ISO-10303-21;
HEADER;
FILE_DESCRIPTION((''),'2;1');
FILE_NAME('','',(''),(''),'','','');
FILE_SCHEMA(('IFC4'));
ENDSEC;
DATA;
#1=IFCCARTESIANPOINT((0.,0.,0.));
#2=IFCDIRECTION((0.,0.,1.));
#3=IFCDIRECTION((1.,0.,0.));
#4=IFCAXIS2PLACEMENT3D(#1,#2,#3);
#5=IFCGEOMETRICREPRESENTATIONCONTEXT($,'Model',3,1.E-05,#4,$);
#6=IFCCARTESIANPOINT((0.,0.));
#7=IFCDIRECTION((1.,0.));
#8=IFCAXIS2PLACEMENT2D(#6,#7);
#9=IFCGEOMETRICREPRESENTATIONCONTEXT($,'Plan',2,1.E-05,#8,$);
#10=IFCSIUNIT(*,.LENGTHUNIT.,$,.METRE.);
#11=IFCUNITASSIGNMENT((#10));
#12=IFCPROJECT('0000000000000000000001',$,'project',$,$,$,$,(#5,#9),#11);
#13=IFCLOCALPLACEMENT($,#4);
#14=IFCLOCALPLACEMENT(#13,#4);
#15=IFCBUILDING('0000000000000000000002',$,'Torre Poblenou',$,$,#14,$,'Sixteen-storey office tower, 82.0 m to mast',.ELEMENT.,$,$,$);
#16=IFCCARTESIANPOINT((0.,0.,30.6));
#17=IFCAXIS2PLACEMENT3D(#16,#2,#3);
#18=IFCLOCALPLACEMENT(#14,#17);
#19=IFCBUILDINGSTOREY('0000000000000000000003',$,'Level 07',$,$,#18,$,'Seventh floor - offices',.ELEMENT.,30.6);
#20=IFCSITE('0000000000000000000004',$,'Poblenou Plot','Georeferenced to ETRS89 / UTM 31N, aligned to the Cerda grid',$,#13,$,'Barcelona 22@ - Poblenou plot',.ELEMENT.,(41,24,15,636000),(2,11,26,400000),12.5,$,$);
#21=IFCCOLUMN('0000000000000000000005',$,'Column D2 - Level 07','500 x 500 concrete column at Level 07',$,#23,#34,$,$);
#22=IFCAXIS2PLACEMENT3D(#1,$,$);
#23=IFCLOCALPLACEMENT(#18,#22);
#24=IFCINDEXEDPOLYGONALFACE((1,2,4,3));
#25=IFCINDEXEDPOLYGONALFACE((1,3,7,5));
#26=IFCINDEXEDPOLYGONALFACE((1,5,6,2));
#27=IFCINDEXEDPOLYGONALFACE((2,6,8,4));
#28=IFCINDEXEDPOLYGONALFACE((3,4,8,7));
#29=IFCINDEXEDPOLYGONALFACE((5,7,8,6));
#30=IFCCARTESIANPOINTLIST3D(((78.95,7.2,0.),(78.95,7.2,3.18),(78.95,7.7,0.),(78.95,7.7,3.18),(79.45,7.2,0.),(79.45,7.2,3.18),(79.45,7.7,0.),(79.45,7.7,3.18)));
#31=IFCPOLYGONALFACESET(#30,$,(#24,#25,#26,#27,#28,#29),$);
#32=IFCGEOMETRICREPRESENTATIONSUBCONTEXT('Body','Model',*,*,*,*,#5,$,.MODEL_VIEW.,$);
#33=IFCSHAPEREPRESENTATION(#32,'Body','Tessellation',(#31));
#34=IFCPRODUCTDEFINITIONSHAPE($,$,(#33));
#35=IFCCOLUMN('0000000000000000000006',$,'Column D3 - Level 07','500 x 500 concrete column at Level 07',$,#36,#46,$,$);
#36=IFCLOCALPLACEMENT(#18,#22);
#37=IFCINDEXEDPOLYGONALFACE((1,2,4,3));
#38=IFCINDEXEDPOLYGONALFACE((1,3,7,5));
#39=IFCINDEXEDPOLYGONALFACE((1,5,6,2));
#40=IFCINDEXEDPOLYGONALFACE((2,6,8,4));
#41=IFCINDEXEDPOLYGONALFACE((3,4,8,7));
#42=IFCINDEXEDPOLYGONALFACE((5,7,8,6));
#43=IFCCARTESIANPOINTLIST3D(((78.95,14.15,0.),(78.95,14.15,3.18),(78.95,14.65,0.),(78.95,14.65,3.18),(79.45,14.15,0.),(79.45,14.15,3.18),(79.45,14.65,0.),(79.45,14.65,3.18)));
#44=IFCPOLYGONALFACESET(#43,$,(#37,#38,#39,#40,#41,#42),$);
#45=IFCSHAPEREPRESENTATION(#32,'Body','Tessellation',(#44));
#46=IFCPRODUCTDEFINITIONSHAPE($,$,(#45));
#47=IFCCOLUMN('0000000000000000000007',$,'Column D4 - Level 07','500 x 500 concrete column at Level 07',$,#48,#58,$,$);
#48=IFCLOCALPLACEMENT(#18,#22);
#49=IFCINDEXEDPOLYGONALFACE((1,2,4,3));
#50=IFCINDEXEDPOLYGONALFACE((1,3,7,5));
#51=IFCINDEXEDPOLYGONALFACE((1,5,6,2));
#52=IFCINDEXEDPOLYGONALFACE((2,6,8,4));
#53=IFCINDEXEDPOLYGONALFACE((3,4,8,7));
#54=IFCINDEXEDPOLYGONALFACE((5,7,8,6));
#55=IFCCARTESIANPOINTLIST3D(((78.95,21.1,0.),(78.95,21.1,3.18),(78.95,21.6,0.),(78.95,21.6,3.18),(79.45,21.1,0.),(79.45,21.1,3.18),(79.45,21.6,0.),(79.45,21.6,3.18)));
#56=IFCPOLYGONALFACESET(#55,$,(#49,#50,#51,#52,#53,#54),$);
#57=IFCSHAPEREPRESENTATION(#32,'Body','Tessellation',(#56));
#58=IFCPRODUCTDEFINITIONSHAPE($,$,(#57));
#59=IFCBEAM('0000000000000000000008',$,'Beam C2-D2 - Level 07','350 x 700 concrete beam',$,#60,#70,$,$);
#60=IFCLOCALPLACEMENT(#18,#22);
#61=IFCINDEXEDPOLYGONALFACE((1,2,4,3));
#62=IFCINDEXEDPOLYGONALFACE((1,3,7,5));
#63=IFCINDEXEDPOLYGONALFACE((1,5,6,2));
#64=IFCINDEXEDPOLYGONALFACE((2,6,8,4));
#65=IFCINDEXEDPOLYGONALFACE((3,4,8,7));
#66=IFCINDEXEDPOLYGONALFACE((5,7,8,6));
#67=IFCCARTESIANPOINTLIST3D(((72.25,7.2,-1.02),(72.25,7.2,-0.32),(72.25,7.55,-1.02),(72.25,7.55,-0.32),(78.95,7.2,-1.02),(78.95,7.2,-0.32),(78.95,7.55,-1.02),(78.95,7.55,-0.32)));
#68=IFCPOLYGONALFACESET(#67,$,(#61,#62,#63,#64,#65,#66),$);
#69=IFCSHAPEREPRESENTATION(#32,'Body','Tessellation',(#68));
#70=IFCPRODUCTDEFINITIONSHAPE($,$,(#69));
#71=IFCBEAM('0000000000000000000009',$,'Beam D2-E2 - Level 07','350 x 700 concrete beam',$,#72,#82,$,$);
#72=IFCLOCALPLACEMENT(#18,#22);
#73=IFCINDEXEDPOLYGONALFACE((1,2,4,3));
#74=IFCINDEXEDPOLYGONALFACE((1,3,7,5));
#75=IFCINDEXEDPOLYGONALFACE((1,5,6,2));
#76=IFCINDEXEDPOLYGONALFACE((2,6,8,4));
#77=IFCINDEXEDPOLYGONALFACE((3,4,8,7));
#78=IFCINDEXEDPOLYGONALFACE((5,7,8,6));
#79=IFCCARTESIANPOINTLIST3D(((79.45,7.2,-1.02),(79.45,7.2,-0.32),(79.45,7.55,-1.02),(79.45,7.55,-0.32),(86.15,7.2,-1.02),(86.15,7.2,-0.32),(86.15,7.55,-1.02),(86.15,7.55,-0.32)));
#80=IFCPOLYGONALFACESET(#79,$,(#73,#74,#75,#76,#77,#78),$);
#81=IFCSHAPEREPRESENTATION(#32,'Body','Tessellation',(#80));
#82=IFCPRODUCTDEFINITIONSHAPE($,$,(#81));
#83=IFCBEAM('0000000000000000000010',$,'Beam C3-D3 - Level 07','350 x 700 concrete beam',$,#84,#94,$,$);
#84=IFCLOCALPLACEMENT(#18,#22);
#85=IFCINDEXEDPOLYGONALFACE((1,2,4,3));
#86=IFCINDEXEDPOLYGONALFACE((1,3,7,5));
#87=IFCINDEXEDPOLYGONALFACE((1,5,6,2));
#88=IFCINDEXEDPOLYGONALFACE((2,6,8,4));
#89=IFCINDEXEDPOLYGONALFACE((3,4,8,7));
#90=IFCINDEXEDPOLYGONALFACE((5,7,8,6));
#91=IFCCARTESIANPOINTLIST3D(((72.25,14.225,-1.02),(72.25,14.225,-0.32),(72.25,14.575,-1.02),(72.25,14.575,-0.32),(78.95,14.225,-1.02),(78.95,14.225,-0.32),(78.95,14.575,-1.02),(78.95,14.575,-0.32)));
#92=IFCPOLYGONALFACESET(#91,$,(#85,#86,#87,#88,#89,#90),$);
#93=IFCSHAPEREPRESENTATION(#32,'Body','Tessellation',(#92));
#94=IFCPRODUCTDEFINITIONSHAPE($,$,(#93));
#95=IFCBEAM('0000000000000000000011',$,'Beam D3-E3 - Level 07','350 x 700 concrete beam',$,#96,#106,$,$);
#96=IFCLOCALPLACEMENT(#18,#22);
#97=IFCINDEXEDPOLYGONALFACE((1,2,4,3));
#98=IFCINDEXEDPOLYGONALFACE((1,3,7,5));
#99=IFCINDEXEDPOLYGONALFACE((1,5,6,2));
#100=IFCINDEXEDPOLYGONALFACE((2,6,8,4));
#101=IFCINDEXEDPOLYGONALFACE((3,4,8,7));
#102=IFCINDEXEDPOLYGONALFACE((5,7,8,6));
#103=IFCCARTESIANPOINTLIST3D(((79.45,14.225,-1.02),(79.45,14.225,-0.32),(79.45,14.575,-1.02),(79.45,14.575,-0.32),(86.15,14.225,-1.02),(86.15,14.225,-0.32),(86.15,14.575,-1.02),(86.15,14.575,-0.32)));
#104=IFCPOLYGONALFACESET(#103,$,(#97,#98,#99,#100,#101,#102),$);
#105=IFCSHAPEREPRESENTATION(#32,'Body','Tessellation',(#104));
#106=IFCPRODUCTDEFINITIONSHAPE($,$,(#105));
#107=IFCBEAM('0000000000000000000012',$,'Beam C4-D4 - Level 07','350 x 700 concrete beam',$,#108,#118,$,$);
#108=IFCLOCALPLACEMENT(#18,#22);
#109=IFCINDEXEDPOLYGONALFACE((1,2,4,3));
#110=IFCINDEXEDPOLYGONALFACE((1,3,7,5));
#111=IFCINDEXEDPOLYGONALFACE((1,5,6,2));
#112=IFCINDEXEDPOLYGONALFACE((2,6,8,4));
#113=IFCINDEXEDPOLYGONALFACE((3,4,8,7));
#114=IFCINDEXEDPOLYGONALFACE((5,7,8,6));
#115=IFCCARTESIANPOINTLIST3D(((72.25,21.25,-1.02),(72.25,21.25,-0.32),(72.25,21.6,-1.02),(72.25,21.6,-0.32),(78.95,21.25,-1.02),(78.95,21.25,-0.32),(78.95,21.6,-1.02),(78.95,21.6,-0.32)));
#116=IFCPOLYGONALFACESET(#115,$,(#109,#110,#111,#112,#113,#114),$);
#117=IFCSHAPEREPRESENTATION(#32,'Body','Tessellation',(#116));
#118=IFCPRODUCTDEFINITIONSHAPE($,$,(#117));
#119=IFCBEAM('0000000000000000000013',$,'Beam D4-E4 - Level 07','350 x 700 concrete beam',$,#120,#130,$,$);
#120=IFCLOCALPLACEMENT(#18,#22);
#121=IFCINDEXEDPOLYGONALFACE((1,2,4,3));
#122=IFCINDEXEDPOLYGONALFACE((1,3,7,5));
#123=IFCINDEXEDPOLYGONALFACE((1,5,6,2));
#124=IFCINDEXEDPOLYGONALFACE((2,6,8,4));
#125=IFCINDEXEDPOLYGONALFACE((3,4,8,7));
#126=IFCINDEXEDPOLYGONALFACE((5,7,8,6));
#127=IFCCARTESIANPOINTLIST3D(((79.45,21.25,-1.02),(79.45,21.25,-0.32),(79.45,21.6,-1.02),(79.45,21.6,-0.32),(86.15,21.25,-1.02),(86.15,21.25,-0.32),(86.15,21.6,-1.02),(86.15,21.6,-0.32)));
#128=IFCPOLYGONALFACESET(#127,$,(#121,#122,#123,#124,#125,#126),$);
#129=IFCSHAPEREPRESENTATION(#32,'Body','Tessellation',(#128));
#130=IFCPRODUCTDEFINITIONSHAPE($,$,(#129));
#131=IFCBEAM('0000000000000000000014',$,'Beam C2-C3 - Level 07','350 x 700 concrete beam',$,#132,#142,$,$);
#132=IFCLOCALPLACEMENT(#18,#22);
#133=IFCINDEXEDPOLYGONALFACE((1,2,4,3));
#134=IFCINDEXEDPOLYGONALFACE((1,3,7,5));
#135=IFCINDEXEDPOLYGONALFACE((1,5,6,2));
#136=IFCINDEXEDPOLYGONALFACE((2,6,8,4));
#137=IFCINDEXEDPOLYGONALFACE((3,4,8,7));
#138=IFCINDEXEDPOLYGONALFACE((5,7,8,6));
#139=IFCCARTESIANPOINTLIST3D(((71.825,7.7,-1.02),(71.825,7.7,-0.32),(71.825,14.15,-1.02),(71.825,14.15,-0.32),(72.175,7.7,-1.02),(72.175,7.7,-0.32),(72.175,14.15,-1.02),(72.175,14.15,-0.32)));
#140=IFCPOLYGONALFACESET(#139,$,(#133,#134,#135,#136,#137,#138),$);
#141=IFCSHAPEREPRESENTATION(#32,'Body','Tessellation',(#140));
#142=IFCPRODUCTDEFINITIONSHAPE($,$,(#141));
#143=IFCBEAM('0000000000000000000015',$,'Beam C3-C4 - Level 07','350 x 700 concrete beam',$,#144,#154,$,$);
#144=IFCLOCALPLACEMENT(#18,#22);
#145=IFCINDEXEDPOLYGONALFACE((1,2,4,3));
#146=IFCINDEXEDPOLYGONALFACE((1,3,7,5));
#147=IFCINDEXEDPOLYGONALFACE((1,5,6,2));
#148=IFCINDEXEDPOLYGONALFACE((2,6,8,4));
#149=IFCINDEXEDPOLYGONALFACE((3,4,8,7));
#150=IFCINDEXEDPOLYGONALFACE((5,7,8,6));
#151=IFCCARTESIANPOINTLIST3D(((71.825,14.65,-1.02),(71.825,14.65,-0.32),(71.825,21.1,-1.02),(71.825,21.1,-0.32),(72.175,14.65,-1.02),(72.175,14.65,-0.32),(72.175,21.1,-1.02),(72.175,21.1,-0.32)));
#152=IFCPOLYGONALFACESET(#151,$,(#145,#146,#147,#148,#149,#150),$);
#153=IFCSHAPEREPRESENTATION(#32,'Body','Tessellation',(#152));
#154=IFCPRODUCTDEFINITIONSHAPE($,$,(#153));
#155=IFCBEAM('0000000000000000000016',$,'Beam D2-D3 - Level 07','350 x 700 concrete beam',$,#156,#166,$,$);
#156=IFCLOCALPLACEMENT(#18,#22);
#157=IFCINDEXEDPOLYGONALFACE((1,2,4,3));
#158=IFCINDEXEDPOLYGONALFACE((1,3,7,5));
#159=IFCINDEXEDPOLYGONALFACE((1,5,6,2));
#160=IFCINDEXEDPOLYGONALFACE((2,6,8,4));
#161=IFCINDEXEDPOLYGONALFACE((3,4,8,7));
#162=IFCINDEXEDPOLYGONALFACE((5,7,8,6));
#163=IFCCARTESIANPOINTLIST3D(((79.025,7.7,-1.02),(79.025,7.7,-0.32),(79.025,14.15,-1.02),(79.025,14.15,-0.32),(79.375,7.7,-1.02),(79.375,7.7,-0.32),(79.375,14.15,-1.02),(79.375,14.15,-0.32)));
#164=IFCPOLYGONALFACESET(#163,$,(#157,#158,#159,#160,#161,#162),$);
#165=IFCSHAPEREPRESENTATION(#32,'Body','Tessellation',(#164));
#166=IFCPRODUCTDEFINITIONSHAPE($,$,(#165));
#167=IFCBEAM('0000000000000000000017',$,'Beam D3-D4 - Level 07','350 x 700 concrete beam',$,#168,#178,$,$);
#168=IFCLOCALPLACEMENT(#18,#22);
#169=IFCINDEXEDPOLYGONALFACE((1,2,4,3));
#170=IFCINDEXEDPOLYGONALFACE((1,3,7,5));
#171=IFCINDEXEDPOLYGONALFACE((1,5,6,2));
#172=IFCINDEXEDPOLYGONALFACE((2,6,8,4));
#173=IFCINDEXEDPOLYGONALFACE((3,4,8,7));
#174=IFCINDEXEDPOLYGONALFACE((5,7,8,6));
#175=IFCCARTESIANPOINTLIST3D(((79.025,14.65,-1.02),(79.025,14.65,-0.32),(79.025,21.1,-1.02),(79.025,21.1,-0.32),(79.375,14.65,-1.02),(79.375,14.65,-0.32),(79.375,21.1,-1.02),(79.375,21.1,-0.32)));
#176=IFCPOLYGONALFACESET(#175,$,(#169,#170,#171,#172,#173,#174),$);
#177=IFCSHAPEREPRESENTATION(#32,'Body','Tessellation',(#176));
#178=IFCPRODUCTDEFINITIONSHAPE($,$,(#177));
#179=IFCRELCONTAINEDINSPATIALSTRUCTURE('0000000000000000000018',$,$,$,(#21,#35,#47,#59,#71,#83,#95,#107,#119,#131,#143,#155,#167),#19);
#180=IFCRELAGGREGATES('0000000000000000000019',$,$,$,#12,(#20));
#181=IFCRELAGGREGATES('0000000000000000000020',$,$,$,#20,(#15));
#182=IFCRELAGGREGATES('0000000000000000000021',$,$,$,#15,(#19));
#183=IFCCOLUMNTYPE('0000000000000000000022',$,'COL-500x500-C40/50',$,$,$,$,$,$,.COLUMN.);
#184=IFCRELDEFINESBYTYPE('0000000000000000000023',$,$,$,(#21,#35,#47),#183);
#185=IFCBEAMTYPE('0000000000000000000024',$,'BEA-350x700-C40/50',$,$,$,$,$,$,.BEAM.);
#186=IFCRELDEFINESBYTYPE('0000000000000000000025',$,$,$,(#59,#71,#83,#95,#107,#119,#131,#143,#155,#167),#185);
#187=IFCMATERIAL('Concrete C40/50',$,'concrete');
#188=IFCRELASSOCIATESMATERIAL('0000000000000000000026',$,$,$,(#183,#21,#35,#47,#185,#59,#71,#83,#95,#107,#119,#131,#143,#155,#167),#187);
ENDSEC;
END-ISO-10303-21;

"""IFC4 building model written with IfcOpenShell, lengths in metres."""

from ifc_helpers import new_model, si_unit, frame, origin_with_axes, origin_2d_with_axis, place, context, subcontext, project, spatial, line, indexed_curve, rectangle, outline, extrude, material, material_profile, profile_set, profile_usage, type_object, element, save


model = new_model("IFC4")

# Units and contexts
model_context = context("Model", 3, precision=1e-05, world=origin_with_axes())
plan_context = context("Plan", 2, precision=1e-05, world=origin_2d_with_axis())
body_context = subcontext(model_context, "Body", "Model", "MODEL_VIEW")
ifc_project = project(units=[si_unit("LENGTHUNIT", "METRE")], contexts=[model_context, plan_context])

# Site, building, storey
site_placement = place(None, origin_with_axes())
site = spatial("IfcSite", under=ifc_project, at=site_placement, Name="Poblenou Plot", Description="Georeferenced to ETRS89 / UTM 31N, aligned to the Cerda grid", LongName="Barcelona 22@ - Poblenou plot", CompositionType="ELEMENT", RefLatitude=(41, 24, 15, 636000), RefLongitude=(2, 11, 26, 400000), RefElevation=12.5)
building_placement = place(site_placement, origin_with_axes())
building = spatial("IfcBuilding", under=site, at=building_placement, Name="Torre Poblenou", LongName="Sixteen-storey office tower, 82.0 m to mast", CompositionType="ELEMENT")
storey_placement = place(building_placement, frame((0.0, 0.0, 30.6), z_axis=(0.0, 0.0, 1.0), x_axis=(1.0, 0.0, 0.0)))
storey = spatial("IfcBuildingStorey", under=building, at=storey_placement, Name="Level 07", LongName="Seventh floor - offices", CompositionType="ELEMENT", Elevation=30.6)

# Columns
ifc_material_1 = material(Name="Concrete C40/50", Category="concrete")
ifc_material_profile_1 = material_profile(ifc_material_1, rectangle(XDim=0.5, YDim=0.5))
ifc_profile_set_1 = profile_set([ifc_material_profile_1], Name="COL-500x500-C40/50")
ifc_profile_usage_1 = profile_usage(ifc_profile_set_1)
column_type = type_object("IfcColumnType", Name="COL-500x500-C40/50", PredefinedType="COLUMN", material=ifc_profile_set_1)
column_1_placement = place(storey_placement, frame((78.95, 7.2, 0.0), z_axis=(0.0, 0.0, 1.0), x_axis=(1.0, 0.0, 0.0)))
element("IfcColumn", 1, at=column_1_placement, inside=storey, type_object=column_type, material=ifc_profile_usage_1, Name="Column D2 - Level 07", Description="500 x 500 concrete column at Level 07", context=body_context, shape_type="SweptSolid", body=[
    extrude(outline(indexed_curve([(0.0, 0.0), (0.5, 0.0), (0.5, 0.5), (0.0, 0.5)], segments=[line(1, 2, 3, 4, 1)])), origin_with_axes(), (0.0, 0.0, 1.0), 3.18),
])
ifc_profile_usage_2 = profile_usage(ifc_profile_set_1)
column_2_placement = place(storey_placement, frame((78.95, 14.15, 0.0), z_axis=(0.0, 0.0, 1.0), x_axis=(1.0, 0.0, 0.0)))
element("IfcColumn", 2, at=column_2_placement, inside=storey, type_object=column_type, material=ifc_profile_usage_2, Name="Column D3 - Level 07", Description="500 x 500 concrete column at Level 07", context=body_context, shape_type="SweptSolid", body=[
    extrude(outline(indexed_curve([(0.0, 0.0), (0.5, 0.0), (0.5, 0.5), (0.0, 0.5)], segments=[line(1, 2, 3, 4, 1)])), origin_with_axes(), (0.0, 0.0, 1.0), 3.18),
])
ifc_profile_usage_3 = profile_usage(ifc_profile_set_1)
column_3_placement = place(storey_placement, frame((78.95, 21.1, 0.0), z_axis=(0.0, 0.0, 1.0), x_axis=(1.0, 0.0, 0.0)))
element("IfcColumn", 3, at=column_3_placement, inside=storey, type_object=column_type, material=ifc_profile_usage_3, Name="Column D4 - Level 07", Description="500 x 500 concrete column at Level 07", context=body_context, shape_type="SweptSolid", body=[
    extrude(outline(indexed_curve([(0.0, 0.0), (0.5, 0.0), (0.5, 0.5), (0.0, 0.5)], segments=[line(1, 2, 3, 4, 1)])), origin_with_axes(), (0.0, 0.0, 1.0), 3.18),
])

# Beams
ifc_material_profile_2 = material_profile(ifc_material_1, rectangle(XDim=0.35, YDim=0.7))
ifc_profile_set_2 = profile_set([ifc_material_profile_2], Name="BEA-350x700-C40/50")
ifc_profile_usage_4 = profile_usage(ifc_profile_set_2)
beam_type = type_object("IfcBeamType", Name="BEA-350x700-C40/50", PredefinedType="BEAM", material=ifc_profile_set_2)
beam_1_placement = place(storey_placement, frame((72.25, 7.2, -1.02), z_axis=(0.0, 0.0, 1.0), x_axis=(1.0, 0.0, 0.0)))
element("IfcBeam", 4, at=beam_1_placement, inside=storey, type_object=beam_type, material=ifc_profile_usage_4, Name="Beam C2-D2 - Level 07", Description="350 x 700 concrete beam", context=body_context, shape_type="SweptSolid", body=[
    extrude(outline(indexed_curve([(0.0, 0.0), (6.7, 0.0), (6.7, 0.35), (0.0, 0.35)], segments=[line(1, 2, 3, 4, 1)])), origin_with_axes(), (0.0, 0.0, 1.0), 0.7),
])
ifc_profile_usage_5 = profile_usage(ifc_profile_set_2)
beam_2_placement = place(storey_placement, frame((79.45, 7.2, -1.02), z_axis=(0.0, 0.0, 1.0), x_axis=(1.0, 0.0, 0.0)))
element("IfcBeam", 5, at=beam_2_placement, inside=storey, type_object=beam_type, material=ifc_profile_usage_5, Name="Beam D2-E2 - Level 07", Description="350 x 700 concrete beam", context=body_context, shape_type="SweptSolid", body=[
    extrude(outline(indexed_curve([(0.0, 0.0), (6.7, 0.0), (6.7, 0.35), (0.0, 0.35)], segments=[line(1, 2, 3, 4, 1)])), origin_with_axes(), (0.0, 0.0, 1.0), 0.7),
])
ifc_profile_usage_6 = profile_usage(ifc_profile_set_2)
beam_3_placement = place(storey_placement, frame((72.25, 14.225, -1.02), z_axis=(0.0, 0.0, 1.0), x_axis=(1.0, 0.0, 0.0)))
element("IfcBeam", 6, at=beam_3_placement, inside=storey, type_object=beam_type, material=ifc_profile_usage_6, Name="Beam C3-D3 - Level 07", Description="350 x 700 concrete beam", context=body_context, shape_type="SweptSolid", body=[
    extrude(outline(indexed_curve([(0.0, 0.0), (6.7, 0.0), (6.7, 0.35), (0.0, 0.35)], segments=[line(1, 2, 3, 4, 1)])), origin_with_axes(), (0.0, 0.0, 1.0), 0.7),
])
ifc_profile_usage_7 = profile_usage(ifc_profile_set_2)
beam_4_placement = place(storey_placement, frame((79.45, 14.225, -1.02), z_axis=(0.0, 0.0, 1.0), x_axis=(1.0, 0.0, 0.0)))
element("IfcBeam", 7, at=beam_4_placement, inside=storey, type_object=beam_type, material=ifc_profile_usage_7, Name="Beam D3-E3 - Level 07", Description="350 x 700 concrete beam", context=body_context, shape_type="SweptSolid", body=[
    extrude(outline(indexed_curve([(0.0, 0.0), (6.7, 0.0), (6.7, 0.35), (0.0, 0.35)], segments=[line(1, 2, 3, 4, 1)])), origin_with_axes(), (0.0, 0.0, 1.0), 0.7),
])
ifc_profile_usage_8 = profile_usage(ifc_profile_set_2)
beam_5_placement = place(storey_placement, frame((72.25, 21.25, -1.02), z_axis=(0.0, 0.0, 1.0), x_axis=(1.0, 0.0, 0.0)))
element("IfcBeam", 8, at=beam_5_placement, inside=storey, type_object=beam_type, material=ifc_profile_usage_8, Name="Beam C4-D4 - Level 07", Description="350 x 700 concrete beam", context=body_context, shape_type="SweptSolid", body=[
    extrude(outline(indexed_curve([(0.0, 0.0), (6.7, 0.0), (6.7, 0.35), (0.0, 0.35)], segments=[line(1, 2, 3, 4, 1)])), origin_with_axes(), (0.0, 0.0, 1.0), 0.7),
])
ifc_profile_usage_9 = profile_usage(ifc_profile_set_2)
beam_6_placement = place(storey_placement, frame((79.45, 21.25, -1.02), z_axis=(0.0, 0.0, 1.0), x_axis=(1.0, 0.0, 0.0)))
element("IfcBeam", 9, at=beam_6_placement, inside=storey, type_object=beam_type, material=ifc_profile_usage_9, Name="Beam D4-E4 - Level 07", Description="350 x 700 concrete beam", context=body_context, shape_type="SweptSolid", body=[
    extrude(outline(indexed_curve([(0.0, 0.0), (6.7, 0.0), (6.7, 0.35), (0.0, 0.35)], segments=[line(1, 2, 3, 4, 1)])), origin_with_axes(), (0.0, 0.0, 1.0), 0.7),
])
ifc_profile_usage_10 = profile_usage(ifc_profile_set_2)
beam_7_placement = place(storey_placement, frame((72.175, 7.7, -1.02), z_axis=(0.0, 0.0, 1.0), x_axis=(0.0, 1.0, 0.0)))
element("IfcBeam", 10, at=beam_7_placement, inside=storey, type_object=beam_type, material=ifc_profile_usage_10, Name="Beam C2-C3 - Level 07", Description="350 x 700 concrete beam", context=body_context, shape_type="SweptSolid", body=[
    extrude(outline(indexed_curve([(0.0, 0.0), (6.45, 0.0), (6.45, 0.35), (0.0, 0.35)], segments=[line(1, 2, 3, 4, 1)])), origin_with_axes(), (0.0, 0.0, 1.0), 0.7),
])
ifc_profile_usage_11 = profile_usage(ifc_profile_set_2)
beam_8_placement = place(storey_placement, frame((72.175, 14.65, -1.02), z_axis=(0.0, 0.0, 1.0), x_axis=(0.0, 1.0, 0.0)))
element("IfcBeam", 11, at=beam_8_placement, inside=storey, type_object=beam_type, material=ifc_profile_usage_11, Name="Beam C3-C4 - Level 07", Description="350 x 700 concrete beam", context=body_context, shape_type="SweptSolid", body=[
    extrude(outline(indexed_curve([(0.0, 0.0), (6.45, 0.0), (6.45, 0.35), (0.0, 0.35)], segments=[line(1, 2, 3, 4, 1)])), origin_with_axes(), (0.0, 0.0, 1.0), 0.7),
])
ifc_profile_usage_12 = profile_usage(ifc_profile_set_2)
beam_9_placement = place(storey_placement, frame((79.375, 7.7, -1.02), z_axis=(0.0, 0.0, 1.0), x_axis=(0.0, 1.0, 0.0)))
element("IfcBeam", 12, at=beam_9_placement, inside=storey, type_object=beam_type, material=ifc_profile_usage_12, Name="Beam D2-D3 - Level 07", Description="350 x 700 concrete beam", context=body_context, shape_type="SweptSolid", body=[
    extrude(outline(indexed_curve([(0.0, 0.0), (6.45, 0.0), (6.45, 0.35), (0.0, 0.35)], segments=[line(1, 2, 3, 4, 1)])), origin_with_axes(), (0.0, 0.0, 1.0), 0.7),
])
ifc_profile_usage_13 = profile_usage(ifc_profile_set_2)
beam_10_placement = place(storey_placement, frame((79.375, 14.65, -1.02), z_axis=(0.0, 0.0, 1.0), x_axis=(0.0, 1.0, 0.0)))
element("IfcBeam", 13, at=beam_10_placement, inside=storey, type_object=beam_type, material=ifc_profile_usage_13, Name="Beam D3-D4 - Level 07", Description="350 x 700 concrete beam", context=body_context, shape_type="SweptSolid", body=[
    extrude(outline(indexed_curve([(0.0, 0.0), (6.45, 0.0), (6.45, 0.35), (0.0, 0.35)], segments=[line(1, 2, 3, 4, 1)])), origin_with_axes(), (0.0, 0.0, 1.0), 0.7),
])

save(model, "model.ifc")
